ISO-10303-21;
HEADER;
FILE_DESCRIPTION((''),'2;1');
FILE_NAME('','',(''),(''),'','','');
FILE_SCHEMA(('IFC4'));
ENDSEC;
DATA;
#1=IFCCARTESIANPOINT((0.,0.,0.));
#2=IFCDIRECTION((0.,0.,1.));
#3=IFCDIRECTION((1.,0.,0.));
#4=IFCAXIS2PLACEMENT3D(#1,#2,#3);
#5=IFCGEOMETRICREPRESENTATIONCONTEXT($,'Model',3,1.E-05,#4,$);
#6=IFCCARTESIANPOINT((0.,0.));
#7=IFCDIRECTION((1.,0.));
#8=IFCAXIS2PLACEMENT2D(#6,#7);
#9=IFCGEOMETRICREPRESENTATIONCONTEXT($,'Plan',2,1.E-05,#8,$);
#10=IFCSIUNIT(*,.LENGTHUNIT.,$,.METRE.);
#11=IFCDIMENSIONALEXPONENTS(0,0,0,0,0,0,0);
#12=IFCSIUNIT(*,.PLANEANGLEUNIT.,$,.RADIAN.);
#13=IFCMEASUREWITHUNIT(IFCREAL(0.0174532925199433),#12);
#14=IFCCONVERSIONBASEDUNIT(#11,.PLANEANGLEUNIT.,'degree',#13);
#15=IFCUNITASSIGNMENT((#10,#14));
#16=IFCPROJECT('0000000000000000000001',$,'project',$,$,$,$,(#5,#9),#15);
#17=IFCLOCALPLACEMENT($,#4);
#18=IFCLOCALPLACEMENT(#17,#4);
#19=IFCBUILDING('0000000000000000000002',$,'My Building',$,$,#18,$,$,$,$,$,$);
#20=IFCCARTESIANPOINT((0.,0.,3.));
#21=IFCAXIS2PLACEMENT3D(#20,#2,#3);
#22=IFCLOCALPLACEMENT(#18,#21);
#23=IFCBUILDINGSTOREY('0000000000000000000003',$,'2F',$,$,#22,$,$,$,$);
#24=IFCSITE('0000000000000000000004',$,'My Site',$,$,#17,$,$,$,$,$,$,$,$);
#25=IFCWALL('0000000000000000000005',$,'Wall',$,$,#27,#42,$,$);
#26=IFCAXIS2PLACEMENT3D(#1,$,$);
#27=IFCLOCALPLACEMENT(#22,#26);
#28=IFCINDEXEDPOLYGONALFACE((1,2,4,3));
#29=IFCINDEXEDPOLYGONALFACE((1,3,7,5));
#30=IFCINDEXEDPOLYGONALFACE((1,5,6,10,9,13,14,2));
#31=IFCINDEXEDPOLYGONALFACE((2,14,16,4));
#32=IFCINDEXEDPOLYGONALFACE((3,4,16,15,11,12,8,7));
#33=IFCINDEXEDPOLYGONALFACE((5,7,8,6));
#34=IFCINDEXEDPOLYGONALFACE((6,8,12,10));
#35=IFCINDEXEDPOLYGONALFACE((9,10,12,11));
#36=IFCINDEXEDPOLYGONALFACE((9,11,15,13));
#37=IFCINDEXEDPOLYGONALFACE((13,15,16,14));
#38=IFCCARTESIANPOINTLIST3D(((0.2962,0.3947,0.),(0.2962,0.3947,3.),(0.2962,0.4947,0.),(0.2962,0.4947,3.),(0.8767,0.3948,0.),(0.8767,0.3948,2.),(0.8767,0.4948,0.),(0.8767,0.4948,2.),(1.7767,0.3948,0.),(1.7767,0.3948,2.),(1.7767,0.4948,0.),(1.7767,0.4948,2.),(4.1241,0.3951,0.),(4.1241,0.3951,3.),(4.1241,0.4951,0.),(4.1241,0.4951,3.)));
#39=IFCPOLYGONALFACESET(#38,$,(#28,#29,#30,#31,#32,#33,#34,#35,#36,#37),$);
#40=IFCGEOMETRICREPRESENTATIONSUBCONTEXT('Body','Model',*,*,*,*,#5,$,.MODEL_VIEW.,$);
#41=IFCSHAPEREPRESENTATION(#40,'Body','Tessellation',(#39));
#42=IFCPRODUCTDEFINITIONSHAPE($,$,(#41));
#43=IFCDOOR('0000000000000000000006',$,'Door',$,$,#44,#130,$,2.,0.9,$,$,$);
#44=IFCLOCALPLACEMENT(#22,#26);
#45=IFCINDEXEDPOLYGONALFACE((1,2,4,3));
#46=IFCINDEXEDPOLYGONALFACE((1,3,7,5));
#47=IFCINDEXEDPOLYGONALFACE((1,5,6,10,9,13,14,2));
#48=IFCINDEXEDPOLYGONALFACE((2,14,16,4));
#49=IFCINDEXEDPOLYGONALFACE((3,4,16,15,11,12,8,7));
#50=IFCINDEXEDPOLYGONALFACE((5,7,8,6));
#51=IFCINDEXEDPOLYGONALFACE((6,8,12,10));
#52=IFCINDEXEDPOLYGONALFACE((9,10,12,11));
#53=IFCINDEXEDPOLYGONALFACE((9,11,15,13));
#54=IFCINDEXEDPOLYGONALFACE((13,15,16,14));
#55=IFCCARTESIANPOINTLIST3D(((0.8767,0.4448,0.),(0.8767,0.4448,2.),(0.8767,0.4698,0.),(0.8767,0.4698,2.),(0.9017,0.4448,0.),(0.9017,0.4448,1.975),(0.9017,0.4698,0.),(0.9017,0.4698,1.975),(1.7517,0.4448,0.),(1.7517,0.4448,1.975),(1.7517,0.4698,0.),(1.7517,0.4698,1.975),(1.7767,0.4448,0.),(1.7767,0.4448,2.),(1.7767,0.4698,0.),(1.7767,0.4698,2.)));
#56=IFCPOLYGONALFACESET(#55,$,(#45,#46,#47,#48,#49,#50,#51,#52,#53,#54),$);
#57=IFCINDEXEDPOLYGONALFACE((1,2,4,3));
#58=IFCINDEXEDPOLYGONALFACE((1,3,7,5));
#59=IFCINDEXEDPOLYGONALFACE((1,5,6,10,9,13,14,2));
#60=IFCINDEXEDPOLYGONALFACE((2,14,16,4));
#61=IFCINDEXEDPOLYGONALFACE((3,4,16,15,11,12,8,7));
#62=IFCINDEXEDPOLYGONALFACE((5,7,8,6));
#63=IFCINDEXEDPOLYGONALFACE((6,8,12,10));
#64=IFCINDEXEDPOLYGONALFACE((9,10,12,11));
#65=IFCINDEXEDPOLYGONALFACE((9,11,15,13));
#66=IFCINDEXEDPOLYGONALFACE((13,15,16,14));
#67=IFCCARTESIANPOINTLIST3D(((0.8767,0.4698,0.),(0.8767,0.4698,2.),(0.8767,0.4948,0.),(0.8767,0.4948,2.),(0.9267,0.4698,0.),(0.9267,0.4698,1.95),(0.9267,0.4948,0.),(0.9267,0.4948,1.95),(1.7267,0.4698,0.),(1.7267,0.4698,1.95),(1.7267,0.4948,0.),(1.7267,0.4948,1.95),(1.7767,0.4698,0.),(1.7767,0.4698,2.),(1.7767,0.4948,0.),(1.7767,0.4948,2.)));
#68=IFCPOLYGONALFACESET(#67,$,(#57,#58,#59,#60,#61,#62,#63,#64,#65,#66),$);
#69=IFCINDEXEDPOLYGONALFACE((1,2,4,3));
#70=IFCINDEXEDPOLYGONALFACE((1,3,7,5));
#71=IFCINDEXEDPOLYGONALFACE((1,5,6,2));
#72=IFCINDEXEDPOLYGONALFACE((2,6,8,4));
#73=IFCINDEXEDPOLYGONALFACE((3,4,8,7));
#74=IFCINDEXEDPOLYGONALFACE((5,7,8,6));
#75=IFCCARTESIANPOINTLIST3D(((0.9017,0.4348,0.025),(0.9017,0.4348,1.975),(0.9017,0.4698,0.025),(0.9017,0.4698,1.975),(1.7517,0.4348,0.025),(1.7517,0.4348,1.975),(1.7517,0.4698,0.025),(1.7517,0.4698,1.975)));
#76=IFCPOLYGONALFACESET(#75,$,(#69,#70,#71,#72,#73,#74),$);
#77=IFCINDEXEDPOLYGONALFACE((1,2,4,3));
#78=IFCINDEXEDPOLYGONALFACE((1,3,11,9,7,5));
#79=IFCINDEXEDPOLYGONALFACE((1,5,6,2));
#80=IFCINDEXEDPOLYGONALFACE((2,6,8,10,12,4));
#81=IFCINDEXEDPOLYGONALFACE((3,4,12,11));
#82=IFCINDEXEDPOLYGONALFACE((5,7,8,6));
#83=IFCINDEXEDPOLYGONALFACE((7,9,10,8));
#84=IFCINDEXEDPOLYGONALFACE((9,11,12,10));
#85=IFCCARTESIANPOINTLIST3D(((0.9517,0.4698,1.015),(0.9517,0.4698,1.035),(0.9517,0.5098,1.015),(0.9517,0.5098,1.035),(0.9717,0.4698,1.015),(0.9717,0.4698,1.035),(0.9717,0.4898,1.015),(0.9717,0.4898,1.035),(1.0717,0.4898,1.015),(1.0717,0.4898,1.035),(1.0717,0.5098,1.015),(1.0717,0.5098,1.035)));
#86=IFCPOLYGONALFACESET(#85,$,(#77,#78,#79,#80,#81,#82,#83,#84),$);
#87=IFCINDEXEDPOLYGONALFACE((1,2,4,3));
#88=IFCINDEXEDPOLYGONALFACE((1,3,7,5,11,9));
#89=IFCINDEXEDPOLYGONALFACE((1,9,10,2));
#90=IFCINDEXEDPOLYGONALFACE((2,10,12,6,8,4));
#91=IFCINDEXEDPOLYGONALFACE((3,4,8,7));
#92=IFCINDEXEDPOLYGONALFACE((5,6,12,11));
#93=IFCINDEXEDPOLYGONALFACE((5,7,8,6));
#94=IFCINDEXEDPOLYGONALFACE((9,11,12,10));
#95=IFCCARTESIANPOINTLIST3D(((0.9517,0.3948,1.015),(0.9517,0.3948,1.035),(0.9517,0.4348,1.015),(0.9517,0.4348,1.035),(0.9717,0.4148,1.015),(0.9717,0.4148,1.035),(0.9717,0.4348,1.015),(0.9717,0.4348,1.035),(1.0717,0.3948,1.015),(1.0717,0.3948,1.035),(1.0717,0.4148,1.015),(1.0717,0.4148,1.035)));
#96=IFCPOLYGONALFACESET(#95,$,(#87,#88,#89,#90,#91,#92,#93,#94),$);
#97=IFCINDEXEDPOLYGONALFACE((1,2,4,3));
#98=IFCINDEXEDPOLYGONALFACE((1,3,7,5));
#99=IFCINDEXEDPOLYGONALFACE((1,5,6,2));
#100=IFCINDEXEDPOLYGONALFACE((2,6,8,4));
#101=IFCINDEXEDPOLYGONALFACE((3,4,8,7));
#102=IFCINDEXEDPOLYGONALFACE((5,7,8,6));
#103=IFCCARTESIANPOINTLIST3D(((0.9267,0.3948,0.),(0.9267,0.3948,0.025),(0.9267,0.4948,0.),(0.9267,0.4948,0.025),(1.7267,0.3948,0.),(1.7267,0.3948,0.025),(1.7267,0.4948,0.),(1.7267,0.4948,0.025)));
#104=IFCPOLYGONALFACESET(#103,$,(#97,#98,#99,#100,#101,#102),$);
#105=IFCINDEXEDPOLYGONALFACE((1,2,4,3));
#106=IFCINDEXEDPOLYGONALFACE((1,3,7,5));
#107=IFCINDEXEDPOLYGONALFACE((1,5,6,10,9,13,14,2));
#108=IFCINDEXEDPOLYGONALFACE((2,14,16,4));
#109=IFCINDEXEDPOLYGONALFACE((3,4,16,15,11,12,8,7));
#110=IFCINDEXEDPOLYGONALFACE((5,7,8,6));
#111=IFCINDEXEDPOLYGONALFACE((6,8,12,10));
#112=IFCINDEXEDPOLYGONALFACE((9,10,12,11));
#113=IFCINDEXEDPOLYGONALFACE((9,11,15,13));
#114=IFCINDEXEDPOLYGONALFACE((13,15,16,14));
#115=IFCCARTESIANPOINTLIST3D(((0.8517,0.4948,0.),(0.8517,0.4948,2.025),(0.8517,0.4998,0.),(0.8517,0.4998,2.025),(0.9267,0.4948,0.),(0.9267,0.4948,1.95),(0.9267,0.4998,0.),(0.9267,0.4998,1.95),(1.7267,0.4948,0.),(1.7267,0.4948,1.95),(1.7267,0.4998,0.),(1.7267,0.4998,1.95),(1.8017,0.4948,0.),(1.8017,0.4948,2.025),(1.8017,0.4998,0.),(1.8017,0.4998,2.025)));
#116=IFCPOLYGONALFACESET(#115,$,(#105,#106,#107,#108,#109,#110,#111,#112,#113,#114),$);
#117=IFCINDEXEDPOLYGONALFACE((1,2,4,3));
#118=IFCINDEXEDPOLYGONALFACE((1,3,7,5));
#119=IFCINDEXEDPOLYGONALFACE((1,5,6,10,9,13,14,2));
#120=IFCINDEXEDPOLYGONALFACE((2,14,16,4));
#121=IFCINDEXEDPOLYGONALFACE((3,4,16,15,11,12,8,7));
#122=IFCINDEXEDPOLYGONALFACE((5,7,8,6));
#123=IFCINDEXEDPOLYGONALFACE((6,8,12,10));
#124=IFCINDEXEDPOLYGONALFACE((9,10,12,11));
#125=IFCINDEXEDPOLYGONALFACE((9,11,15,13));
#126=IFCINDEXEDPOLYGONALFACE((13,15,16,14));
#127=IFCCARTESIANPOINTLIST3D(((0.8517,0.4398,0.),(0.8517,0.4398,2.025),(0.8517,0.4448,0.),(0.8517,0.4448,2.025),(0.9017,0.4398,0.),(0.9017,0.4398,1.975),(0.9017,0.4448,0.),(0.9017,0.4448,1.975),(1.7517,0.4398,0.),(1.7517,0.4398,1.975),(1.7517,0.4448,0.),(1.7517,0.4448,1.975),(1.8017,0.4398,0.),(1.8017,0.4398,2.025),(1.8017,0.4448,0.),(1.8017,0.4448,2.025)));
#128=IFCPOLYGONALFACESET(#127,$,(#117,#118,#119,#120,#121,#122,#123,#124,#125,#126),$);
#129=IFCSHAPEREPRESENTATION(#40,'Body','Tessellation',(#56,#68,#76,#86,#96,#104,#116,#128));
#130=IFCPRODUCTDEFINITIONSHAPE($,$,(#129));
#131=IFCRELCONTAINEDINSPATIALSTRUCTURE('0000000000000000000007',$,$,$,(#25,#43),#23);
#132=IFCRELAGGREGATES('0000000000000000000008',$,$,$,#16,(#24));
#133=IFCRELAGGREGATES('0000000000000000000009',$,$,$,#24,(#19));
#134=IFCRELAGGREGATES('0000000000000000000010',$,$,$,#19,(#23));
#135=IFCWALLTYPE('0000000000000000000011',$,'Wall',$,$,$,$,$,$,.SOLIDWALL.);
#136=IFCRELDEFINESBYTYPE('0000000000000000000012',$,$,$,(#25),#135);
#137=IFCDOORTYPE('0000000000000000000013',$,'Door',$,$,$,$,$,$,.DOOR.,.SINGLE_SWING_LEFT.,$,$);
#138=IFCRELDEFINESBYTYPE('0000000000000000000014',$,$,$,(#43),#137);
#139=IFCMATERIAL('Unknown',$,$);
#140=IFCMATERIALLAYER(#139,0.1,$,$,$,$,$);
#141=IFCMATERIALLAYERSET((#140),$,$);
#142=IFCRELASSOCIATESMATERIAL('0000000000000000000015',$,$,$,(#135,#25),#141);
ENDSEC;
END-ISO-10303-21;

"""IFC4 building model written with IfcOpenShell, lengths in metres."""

from ifc_helpers import new_model, entity, si_unit, converted_unit, frame, origin_with_axes, origin_2d_with_axis, place, context, subcontext, project, spatial, line, indexed_curve, outline, extrude, shape, source, transform, mapped, material, layer, layer_set, layer_usage, type_object, type_shapes, element, fill, save


model = new_model("IFC4")

# Units and contexts
model_context = context("Model", 3, precision=1e-05, world=origin_with_axes())
plan_context = context("Plan", 2, precision=1e-05, world=origin_2d_with_axis())
body_context_1 = subcontext(model_context, "Body", "Model", "MODEL_VIEW")
body_context_2 = subcontext(plan_context, "Body", "Plan", "PLAN_VIEW")
ifc_project = project(units=[si_unit("LENGTHUNIT", "METRE"), converted_unit("PLANEANGLEUNIT", "degree", entity("IfcReal", 0.0174532925199433), si_unit("PLANEANGLEUNIT", "RADIAN"), dimensions=[0, 0, 0, 0, 0, 0, 0])], contexts=[model_context, plan_context])

# Site, building, storey
site_placement = place(None, origin_with_axes())
site = spatial("IfcSite", under=ifc_project, at=site_placement, Name="My Site")
building_placement = place(site_placement, origin_with_axes())
building = spatial("IfcBuilding", under=site, at=building_placement, Name="My Building")
storey_placement = place(building_placement, frame((0.0, 0.0, 3.0), z_axis=(0.0, 0.0, 1.0), x_axis=(1.0, 0.0, 0.0)))
storey = spatial("IfcBuildingStorey", under=building, at=storey_placement, Name="2F")

# Shared definitions
ifc_material = material(Name="Unknown")

# Shared definitions
ifc_layer = layer(ifc_material, 0.1)
ifc_layer_set = layer_set([ifc_layer])
wall_type = type_object("IfcWallType", Name="Wall", PredefinedType="SOLIDWALL", material=ifc_layer_set)

# Wall, opening, door
shared_shape_1 = source(origin_with_axes(), body_context_1, "Body", "SweptSolid", [
    extrude(outline(indexed_curve([(0.0, 0.0), (0.9, 0.0), (0.9, 2.0), (0.0, 2.0)], segments=[line(1, 2, 3, 4, 1)])), frame((0.0, -0.6, 0.0), z_axis=(0.0, -1.0, 0.0), x_axis=(1.0, 0.0, 0.0)), (0.0, 0.0, -1.0), 1.2),
])
door_type = type_object("IfcDoorType", Name="Door", OperationType="SINGLE_SWING_LEFT", PredefinedType="DOOR")
shared_shape_2 = source(origin_with_axes(), body_context_1, "Body", "SweptSolid", [
    extrude(outline(indexed_curve([(0.0, 0.0), (0.0, 2.0), (0.9, 2.0), (0.9, 0.0), (0.875, 0.0), (0.875, 1.975), (0.025, 1.975), (0.025, 0.0)], segments=[line(1, 2, 3, 4, 5, 6, 7, 8, 1)])), frame((0.0, 0.025, 0.0), z_axis=(0.0, -1.0, 0.0), x_axis=(1.0, 0.0, 0.0)), (0.0, 0.0, -1.0), 0.025),
    extrude(outline(indexed_curve([(0.0, 0.0), (0.0, 2.0), (0.9, 2.0), (0.9, 0.0), (0.85, 0.0), (0.85, 1.95), (0.05, 1.95), (0.05, 0.0)], segments=[line(1, 2, 3, 4, 5, 6, 7, 8, 1)])), frame((0.0, 0.0, 0.0), z_axis=(0.0, -1.0, 0.0), x_axis=(1.0, 0.0, 0.0)), (0.0, 0.0, -1.0), 0.025),
    extrude(outline(indexed_curve([(0.0, 0.0), (0.85, 0.0), (0.85, 0.035), (0.0, 0.035)], segments=[line(1, 2, 3, 4, 1)])), frame((0.025, 0.025, 0.025), z_axis=(0.0, 0.0, 1.0), x_axis=(1.0, 0.0, 0.0)), (0.0, 0.0, 1.0), 1.95),
    extrude(outline(indexed_curve([(0.0, 0.0), (0.0, -0.04), (-0.12, -0.04), (-0.12, -0.02), (-0.02, -0.02), (-0.02, 0.0)], segments=[line(1, 2, 3, 4, 5, 6, 1)])), frame((0.825, 0.025, 1.015), z_axis=(0.0, 0.0, 1.0), x_axis=(1.0, 0.0, 0.0)), (0.0, 0.0, 1.0), 0.02),
    extrude(outline(indexed_curve([(0.0, 0.0), (0.0, 0.04), (-0.12, 0.04), (-0.12, 0.02), (-0.02, 0.02), (-0.02, 0.0)], segments=[line(1, 2, 3, 4, 5, 6, 1)])), frame((0.825, 0.06, 1.015), z_axis=(0.0, 0.0, 1.0), x_axis=(1.0, 0.0, 0.0)), (0.0, 0.0, 1.0), 0.02),
    extrude(outline(indexed_curve([(0.0, 0.0), (0.8, 0.0), (0.8, 0.1), (0.0, 0.1)], segments=[line(1, 2, 3, 4, 1)])), frame((0.05, 0.0, 0.0), z_axis=(0.0, 0.0, 1.0), x_axis=(1.0, 0.0, 0.0)), (0.0, 0.0, 1.0), 0.025),
    extrude(outline(indexed_curve([(0.0, 0.0), (0.0, 2.025), (0.95, 2.025), (0.95, 0.0), (0.875, 0.0), (0.875, 1.95), (0.075, 1.95), (0.075, 0.0)], segments=[line(1, 2, 3, 4, 5, 6, 7, 8, 1)])), frame((-0.025, -0.005, 0.0), z_axis=(0.0, -1.0, 0.0), x_axis=(1.0, 0.0, 0.0)), (0.0, 0.0, -1.0), 0.005),
    extrude(outline(indexed_curve([(0.0, 0.0), (0.0, 2.025), (0.95, 2.025), (0.95, 0.0), (0.9, 0.0), (0.9, 1.975), (0.05, 1.975), (0.05, 0.0)], segments=[line(1, 2, 3, 4, 5, 6, 7, 8, 1)])), frame((-0.025, 0.05, 0.0), z_axis=(0.0, -1.0, 0.0), x_axis=(1.0, 0.0, 0.0)), (0.0, 0.0, -1.0), 0.005),
])
shared_shape_3 = source(origin_with_axes(), body_context_2, "Body", "Curve2D", [
    entity("IfcIndexedPolyCurve", entity("IfcCartesianPointList2D", [[0.0, 0.0], [0.0, 0.05], [0.025, 0.05], [0.025, 0.025], [0.05, 0.025], [0.05, 0.0]]), [entity("IfcLineIndex", [1, 2, 3, 4, 5, 6, 1])]),
    entity("IfcIndexedPolyCurve", entity("IfcCartesianPointList2D", [[0.9, 0.0], [0.9, 0.05], [0.875, 0.05], [0.875, 0.025], [0.85, 0.025], [0.85, 0.0]]), [entity("IfcLineIndex", [1, 2, 3, 4, 5, 6, 1])]),
    entity("IfcTrimmedCurve", entity("IfcEllipse", entity("IfcAxis2Placement2D", entity("IfcCartesianPoint", [0.06, 0.05]), entity("IfcDirection", [1.0, 0.0])), 0.815, 0.85), [entity("IfcCartesianPoint", [0.875, 0.05])], [entity("IfcCartesianPoint", [0.06, 0.9])], True, "CARTESIAN"),
    entity("IfcIndexedPolyCurve", entity("IfcCartesianPointList2D", [[0.025, 0.05], [0.06, 0.05], [0.06, 0.9], [0.025, 0.9]]), [entity("IfcLineIndex", [1, 2, 3, 4, 1])]),
])
type_shapes(door_type, [shared_shape_2, shared_shape_3])
ifc_layer_usage_1 = layer_usage(ifc_layer_set, "AXIS2", "POSITIVE", 0.0)
wall_1_placement = place(storey_placement, frame((4.1241, 0.4951, 0.0), z_axis=(0.0, 0.0, 1.0), x_axis=(-1.0, -0.000094, 0.0)))
wall_1 = element("IfcWall", 1, at=wall_1_placement, inside=storey, type_object=wall_type, material=ifc_layer_usage_1, Name="Wall", context=body_context_1, shape_type="SweptSolid", body=[
    extrude(outline(indexed_curve([(0.0, 0.0), (0.0, 0.1), (3.8279, 0.1), (3.8279, 0.0)], segments=[line(1, 2, 3, 4, 1)])), origin_with_axes(), (0.0, 0.0, 1.0), 3.0),
])
opening_1_placement = place(wall_1_placement, frame((2.3474, 0.0, 0.0), z_axis=(0.0, 0.0, 1.0), x_axis=(1.0, 0.0, 0.0)))
opening_1 = element("IfcOpeningElement", 2, at=opening_1_placement, cuts=wall_1, PredefinedType="OPENING", context=body_context_1, shape_type="MappedRepresentation", body=[
    mapped(shared_shape_1, transform((0.0, 0.0, 0.0), x_axis=(1.0, 0.0, 0.0), y_axis=(0.0, 1.0, 0.0), z_axis=(0.0, 0.0, 1.0), scale=1.0)),
])
door_1_placement = place(opening_1_placement, origin_with_axes())
door_1 = element("IfcDoor", 3, at=door_1_placement, inside=storey, type_object=door_type, Name="Door", OverallHeight=2.0, OverallWidth=0.9, shapes=[
    shape(body_context_1, "Body", "MappedRepresentation", [mapped(shared_shape_2, transform((0.0, 0.0, 0.0), x_axis=(1.0, 0.0, 0.0), y_axis=(0.0, 1.0, 0.0), z_axis=(0.0, 0.0, 1.0), scale=1.0))]),
    shape(body_context_2, "Body", "MappedRepresentation", [mapped(shared_shape_3, transform((0.0, 0.0, 0.0), x_axis=(1.0, 0.0, 0.0), y_axis=(0.0, 1.0, 0.0), z_axis=(0.0, 0.0, 1.0), scale=1.0))]),
])
fill(opening_1, door_1)

save(model, "model.ifc")
